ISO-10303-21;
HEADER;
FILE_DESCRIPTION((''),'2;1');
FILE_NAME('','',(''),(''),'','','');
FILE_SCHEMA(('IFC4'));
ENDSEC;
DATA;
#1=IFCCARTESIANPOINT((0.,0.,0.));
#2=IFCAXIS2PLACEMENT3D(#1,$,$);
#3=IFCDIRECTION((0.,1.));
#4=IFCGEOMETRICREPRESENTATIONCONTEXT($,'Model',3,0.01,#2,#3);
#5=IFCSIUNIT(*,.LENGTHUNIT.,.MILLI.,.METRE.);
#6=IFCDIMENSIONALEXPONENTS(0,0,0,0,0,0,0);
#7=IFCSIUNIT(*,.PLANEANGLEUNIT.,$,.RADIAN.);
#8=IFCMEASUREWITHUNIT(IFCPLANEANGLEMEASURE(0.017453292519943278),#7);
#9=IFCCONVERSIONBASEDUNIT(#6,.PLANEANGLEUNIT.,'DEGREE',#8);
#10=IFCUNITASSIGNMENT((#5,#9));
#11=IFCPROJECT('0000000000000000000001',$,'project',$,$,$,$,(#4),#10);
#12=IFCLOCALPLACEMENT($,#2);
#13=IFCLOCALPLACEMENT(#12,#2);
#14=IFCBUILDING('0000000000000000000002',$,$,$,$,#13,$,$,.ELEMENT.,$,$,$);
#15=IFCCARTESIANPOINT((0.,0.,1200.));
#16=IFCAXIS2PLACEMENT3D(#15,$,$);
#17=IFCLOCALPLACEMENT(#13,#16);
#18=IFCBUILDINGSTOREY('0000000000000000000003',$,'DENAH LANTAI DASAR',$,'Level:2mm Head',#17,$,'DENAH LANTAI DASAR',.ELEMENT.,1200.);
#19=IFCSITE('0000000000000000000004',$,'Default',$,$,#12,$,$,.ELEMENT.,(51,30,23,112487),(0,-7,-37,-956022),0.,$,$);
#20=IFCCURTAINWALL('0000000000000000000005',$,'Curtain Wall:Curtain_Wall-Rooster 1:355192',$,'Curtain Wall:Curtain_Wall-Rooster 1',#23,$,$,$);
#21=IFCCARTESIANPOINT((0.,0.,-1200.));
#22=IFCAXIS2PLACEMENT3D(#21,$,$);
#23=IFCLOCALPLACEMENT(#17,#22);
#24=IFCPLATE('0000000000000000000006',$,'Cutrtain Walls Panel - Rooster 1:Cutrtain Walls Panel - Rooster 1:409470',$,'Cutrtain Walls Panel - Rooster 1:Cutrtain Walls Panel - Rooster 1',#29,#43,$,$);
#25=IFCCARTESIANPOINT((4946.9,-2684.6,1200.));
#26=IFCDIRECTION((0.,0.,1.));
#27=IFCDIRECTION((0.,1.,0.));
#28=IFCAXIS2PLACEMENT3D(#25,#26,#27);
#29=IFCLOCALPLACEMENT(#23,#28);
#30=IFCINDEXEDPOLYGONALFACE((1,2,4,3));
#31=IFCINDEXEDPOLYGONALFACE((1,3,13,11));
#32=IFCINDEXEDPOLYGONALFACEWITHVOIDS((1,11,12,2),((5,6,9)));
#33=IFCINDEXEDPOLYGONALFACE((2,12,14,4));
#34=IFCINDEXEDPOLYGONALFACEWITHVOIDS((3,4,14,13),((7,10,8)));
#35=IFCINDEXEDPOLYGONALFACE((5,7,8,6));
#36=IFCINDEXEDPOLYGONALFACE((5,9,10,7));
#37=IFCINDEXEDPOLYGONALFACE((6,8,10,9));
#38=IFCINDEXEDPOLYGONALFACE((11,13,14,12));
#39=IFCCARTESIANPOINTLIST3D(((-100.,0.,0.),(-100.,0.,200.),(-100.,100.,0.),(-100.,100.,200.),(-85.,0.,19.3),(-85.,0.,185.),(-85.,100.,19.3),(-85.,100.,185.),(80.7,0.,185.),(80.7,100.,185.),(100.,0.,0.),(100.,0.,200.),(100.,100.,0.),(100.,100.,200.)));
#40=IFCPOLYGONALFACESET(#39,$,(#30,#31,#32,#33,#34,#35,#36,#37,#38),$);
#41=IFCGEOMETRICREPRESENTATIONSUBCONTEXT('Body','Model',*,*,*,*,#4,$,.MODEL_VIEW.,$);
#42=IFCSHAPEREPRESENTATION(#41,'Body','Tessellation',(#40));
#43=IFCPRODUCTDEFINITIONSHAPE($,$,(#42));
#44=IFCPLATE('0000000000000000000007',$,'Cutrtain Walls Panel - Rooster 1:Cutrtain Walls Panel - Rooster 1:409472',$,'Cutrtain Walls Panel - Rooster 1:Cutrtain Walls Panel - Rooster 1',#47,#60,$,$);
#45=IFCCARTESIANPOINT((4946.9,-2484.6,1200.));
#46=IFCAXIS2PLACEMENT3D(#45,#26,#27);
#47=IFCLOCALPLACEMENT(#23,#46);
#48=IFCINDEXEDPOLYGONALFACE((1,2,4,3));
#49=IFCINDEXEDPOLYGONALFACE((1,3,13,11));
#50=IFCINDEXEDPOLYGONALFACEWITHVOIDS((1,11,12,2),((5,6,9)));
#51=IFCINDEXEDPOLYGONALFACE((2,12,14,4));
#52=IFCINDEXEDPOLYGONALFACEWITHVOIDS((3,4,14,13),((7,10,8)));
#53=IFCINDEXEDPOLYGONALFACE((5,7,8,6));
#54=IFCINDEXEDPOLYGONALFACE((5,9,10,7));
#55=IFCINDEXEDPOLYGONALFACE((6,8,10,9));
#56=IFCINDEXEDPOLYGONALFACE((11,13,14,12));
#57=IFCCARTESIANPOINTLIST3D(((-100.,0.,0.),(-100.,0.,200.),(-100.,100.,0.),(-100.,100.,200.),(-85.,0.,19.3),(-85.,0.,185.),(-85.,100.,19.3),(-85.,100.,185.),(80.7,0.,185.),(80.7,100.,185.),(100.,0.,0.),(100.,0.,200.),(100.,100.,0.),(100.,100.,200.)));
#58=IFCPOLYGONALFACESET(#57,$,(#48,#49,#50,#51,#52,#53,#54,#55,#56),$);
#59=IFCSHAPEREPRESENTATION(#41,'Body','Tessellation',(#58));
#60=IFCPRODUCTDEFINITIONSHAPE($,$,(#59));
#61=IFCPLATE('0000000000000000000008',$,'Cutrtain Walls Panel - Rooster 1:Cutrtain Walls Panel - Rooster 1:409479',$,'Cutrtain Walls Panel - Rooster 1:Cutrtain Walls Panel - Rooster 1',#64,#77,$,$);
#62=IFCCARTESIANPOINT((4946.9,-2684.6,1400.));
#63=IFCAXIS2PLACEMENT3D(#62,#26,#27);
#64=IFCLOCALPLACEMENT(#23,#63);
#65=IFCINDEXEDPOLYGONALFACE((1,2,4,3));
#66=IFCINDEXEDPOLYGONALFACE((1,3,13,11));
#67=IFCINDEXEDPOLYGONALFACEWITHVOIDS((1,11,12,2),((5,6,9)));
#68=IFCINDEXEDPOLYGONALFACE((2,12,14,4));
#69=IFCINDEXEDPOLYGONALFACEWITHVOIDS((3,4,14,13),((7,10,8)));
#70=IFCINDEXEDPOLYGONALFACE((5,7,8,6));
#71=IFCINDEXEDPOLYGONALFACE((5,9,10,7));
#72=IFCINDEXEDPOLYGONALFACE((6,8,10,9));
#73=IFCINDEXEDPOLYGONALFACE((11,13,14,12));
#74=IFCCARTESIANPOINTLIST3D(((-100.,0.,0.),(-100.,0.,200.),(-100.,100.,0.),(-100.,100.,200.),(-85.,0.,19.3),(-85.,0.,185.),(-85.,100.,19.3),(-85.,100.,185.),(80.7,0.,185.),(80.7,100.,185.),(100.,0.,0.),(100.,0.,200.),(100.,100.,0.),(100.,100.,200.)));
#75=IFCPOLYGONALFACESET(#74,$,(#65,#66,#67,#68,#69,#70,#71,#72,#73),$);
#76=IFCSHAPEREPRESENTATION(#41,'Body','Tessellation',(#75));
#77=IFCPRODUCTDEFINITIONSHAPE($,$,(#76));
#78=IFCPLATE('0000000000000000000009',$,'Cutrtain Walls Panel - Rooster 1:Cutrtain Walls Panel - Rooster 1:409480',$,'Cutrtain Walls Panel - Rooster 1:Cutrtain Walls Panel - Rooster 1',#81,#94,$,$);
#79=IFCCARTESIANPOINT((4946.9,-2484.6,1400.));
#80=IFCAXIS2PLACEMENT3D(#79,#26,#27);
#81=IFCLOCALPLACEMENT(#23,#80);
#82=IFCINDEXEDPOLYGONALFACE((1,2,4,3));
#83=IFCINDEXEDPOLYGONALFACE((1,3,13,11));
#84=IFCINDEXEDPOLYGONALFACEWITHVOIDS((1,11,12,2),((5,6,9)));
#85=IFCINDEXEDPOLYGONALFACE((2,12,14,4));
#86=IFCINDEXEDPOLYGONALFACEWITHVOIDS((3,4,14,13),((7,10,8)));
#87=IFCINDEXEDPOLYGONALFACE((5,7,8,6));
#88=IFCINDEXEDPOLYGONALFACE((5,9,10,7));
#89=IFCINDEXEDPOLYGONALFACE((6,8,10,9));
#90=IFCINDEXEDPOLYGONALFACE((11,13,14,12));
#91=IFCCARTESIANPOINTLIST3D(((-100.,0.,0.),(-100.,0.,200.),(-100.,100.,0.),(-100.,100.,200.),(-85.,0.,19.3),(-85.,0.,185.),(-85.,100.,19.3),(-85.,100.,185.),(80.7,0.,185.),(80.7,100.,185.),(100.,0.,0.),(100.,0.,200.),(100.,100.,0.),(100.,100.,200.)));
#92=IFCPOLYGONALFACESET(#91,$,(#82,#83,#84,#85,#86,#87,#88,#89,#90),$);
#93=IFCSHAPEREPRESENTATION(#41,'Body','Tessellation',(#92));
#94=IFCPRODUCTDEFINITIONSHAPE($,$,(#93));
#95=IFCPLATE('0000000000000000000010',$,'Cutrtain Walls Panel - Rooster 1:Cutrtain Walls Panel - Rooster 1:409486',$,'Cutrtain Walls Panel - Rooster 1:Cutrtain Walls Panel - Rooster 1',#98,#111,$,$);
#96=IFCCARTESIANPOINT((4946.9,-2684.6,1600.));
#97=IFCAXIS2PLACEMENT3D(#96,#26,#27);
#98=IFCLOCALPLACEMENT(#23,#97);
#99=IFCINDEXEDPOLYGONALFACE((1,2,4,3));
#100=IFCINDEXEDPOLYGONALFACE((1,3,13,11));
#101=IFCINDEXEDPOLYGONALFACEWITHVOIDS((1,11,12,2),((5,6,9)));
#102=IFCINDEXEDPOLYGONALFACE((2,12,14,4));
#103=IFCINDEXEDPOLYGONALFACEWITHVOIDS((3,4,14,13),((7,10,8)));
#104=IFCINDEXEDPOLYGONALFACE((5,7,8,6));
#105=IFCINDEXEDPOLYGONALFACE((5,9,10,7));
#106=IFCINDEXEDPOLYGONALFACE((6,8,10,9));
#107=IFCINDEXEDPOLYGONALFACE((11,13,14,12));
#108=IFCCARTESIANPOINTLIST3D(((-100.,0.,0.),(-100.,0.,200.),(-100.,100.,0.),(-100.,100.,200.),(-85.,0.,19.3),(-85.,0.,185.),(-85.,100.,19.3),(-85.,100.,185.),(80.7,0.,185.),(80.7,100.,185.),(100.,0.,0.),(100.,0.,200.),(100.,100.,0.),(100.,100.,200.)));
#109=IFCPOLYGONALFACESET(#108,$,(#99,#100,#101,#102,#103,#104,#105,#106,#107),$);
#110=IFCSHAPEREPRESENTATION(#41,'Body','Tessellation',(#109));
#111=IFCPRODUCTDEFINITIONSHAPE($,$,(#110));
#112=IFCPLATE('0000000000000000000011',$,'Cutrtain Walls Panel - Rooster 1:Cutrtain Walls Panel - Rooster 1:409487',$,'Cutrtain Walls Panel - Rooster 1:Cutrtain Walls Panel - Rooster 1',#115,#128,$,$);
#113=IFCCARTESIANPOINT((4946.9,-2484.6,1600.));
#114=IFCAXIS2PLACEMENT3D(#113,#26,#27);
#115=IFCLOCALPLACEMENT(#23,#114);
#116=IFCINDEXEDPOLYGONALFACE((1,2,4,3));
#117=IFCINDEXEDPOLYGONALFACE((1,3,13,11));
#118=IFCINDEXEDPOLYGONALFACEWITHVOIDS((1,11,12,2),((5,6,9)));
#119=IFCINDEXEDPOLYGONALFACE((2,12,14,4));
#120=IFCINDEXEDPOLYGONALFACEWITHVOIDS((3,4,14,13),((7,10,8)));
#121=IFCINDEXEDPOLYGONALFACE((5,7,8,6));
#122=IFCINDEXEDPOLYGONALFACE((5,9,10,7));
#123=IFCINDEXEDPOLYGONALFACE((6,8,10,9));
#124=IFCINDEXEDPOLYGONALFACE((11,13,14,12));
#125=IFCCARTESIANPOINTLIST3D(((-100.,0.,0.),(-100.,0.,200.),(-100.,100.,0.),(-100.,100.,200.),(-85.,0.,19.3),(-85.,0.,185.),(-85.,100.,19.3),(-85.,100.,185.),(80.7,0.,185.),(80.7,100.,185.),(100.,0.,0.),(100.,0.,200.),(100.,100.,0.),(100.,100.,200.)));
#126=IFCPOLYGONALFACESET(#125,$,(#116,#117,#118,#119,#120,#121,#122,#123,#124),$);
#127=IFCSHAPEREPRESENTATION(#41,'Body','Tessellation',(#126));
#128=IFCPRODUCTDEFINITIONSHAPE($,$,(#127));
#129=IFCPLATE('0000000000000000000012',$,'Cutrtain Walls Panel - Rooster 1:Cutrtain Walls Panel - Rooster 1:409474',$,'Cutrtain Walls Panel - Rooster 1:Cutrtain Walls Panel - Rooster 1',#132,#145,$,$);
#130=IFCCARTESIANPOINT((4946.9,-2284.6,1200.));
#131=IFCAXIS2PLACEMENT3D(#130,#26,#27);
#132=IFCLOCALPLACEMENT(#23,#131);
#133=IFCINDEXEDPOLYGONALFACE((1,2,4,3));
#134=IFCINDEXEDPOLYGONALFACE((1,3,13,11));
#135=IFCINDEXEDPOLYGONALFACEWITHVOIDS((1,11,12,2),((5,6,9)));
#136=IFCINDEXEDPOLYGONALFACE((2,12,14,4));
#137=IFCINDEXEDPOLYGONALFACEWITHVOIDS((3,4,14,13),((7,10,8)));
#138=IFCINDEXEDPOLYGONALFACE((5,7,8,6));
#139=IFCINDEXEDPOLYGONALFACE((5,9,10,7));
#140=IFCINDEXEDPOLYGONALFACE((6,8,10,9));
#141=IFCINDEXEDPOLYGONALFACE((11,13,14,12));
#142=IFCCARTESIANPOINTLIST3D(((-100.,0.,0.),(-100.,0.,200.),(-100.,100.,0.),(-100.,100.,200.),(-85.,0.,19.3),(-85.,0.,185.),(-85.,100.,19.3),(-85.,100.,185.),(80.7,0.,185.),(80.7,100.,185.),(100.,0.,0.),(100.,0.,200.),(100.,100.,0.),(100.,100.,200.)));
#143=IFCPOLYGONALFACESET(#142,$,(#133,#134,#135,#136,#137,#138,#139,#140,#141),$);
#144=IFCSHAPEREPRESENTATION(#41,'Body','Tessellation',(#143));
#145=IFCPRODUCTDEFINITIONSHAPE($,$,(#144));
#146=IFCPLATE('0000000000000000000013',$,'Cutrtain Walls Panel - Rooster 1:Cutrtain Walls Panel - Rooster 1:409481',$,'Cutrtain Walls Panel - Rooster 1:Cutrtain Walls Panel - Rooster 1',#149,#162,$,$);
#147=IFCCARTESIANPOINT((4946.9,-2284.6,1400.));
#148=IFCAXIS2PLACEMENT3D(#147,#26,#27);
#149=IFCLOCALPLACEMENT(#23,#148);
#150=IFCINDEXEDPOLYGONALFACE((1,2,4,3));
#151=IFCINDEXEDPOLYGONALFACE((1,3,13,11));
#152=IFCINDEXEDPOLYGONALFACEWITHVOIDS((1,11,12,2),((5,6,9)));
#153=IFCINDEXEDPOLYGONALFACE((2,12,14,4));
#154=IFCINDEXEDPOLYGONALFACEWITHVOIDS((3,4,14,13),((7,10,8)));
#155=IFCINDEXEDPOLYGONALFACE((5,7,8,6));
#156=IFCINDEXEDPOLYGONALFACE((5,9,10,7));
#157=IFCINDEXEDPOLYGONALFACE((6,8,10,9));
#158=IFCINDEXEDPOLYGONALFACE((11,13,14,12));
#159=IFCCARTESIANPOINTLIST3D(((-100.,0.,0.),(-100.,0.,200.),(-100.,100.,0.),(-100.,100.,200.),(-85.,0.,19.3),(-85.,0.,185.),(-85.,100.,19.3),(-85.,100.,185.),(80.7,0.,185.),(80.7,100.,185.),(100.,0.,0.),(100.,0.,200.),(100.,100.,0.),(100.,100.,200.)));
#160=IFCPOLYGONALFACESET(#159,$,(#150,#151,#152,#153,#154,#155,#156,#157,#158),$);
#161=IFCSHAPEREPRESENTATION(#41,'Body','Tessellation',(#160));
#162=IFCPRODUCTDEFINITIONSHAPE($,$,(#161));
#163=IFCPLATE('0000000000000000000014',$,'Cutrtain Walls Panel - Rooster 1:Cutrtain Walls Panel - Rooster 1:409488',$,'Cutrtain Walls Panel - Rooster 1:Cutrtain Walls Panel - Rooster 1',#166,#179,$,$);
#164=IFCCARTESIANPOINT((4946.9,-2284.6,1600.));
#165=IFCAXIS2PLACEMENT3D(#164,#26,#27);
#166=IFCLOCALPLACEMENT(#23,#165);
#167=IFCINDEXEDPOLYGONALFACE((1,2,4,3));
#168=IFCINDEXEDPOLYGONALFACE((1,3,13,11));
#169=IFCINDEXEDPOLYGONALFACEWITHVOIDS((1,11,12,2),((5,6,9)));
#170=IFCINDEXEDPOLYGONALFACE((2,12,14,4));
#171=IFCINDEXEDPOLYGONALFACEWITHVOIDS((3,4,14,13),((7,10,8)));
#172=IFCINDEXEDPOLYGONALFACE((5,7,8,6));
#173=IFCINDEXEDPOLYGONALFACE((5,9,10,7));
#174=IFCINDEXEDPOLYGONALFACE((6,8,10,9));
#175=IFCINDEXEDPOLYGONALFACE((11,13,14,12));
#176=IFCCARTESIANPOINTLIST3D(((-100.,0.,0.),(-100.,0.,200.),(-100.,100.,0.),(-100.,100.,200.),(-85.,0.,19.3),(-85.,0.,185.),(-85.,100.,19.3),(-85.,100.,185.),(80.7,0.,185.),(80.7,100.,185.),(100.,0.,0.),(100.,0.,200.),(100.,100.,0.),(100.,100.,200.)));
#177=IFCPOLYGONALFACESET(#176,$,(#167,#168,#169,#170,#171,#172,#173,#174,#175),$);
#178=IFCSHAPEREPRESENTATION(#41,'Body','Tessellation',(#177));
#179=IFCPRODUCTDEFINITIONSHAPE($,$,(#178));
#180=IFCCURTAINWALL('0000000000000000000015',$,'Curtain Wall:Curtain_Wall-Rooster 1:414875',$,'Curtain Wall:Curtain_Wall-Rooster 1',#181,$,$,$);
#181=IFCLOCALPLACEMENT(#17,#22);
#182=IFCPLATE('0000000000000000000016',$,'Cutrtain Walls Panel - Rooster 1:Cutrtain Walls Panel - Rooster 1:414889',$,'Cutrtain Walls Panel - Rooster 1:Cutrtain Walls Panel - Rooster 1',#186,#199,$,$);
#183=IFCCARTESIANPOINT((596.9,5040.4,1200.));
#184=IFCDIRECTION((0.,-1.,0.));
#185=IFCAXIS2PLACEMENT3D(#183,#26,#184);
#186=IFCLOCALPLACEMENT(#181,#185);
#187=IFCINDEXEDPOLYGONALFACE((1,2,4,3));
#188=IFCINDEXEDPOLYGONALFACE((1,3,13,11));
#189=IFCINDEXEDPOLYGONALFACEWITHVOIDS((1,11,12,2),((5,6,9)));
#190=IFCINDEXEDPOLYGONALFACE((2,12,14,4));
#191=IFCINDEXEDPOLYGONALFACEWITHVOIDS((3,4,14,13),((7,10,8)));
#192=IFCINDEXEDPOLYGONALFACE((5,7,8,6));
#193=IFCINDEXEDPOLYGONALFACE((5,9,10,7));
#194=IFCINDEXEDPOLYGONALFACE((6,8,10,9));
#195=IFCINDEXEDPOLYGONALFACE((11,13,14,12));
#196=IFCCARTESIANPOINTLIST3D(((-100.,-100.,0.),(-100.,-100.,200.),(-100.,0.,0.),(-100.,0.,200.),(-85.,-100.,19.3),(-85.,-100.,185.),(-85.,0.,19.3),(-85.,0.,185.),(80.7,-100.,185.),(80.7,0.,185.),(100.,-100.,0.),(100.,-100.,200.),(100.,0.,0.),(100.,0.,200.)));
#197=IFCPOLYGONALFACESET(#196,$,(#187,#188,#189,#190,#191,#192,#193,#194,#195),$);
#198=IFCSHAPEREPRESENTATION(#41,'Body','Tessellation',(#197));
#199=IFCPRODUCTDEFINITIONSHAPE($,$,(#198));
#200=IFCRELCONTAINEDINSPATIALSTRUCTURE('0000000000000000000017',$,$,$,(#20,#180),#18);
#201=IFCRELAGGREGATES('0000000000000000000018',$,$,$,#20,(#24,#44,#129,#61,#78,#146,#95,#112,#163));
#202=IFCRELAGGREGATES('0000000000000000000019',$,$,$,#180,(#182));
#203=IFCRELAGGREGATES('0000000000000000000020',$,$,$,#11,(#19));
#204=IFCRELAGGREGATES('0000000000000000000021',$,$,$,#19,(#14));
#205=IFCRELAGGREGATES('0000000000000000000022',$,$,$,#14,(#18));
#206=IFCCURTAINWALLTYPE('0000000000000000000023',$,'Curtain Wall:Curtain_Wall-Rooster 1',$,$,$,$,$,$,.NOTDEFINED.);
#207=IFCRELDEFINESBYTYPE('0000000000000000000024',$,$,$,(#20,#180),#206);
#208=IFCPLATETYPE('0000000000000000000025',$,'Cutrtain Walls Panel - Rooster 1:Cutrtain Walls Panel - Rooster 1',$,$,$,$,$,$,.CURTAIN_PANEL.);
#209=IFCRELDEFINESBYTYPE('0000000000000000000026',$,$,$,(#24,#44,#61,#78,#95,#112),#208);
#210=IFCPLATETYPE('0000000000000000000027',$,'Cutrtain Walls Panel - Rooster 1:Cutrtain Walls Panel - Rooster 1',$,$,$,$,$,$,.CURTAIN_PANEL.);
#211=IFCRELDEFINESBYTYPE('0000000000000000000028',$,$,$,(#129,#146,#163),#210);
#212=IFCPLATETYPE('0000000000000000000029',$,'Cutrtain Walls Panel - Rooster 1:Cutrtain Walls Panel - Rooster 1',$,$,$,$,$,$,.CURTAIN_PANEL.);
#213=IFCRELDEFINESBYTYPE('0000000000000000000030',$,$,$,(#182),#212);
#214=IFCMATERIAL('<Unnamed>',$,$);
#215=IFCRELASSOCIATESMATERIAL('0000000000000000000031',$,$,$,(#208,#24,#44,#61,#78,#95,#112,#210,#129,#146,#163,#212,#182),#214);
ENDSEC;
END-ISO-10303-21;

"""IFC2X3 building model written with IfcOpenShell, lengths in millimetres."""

from ifc_helpers import new_model, entity, si_unit, converted_unit, direction, frame, origin, place, context, subcontext, project, spatial, polyline, outline, extrude, source, transform, mapped, material, type_object, type_shapes, element, aggregate, save


model = new_model("IFC2X3")

# Units and contexts
model_context = context("Model", 3, precision=0.01, world=origin(), true_north=direction((0.0, 1.0)))
body_context = subcontext(model_context, "Body", "Model", "MODEL_VIEW")
ifc_project = project(units=[si_unit("LENGTHUNIT", "METRE", prefix="MILLI"), converted_unit("PLANEANGLEUNIT", "DEGREE", entity("IfcPlaneAngleMeasure", 0.017453292519943278), si_unit("PLANEANGLEUNIT", "RADIAN"), dimensions=[0, 0, 0, 0, 0, 0, 0])], contexts=[model_context])

# Site, building, storey
site_placement = place(None, origin())
site = spatial("IfcSite", under=ifc_project, at=site_placement, Name="Default", CompositionType="ELEMENT", RefLatitude=(51, 30, 23, 112487), RefLongitude=(0, -7, -37, -956022), RefElevation=0.0)
building_placement = place(site_placement, origin())
building = spatial("IfcBuilding", under=site, at=building_placement, CompositionType="ELEMENT")
storey_placement = place(building_placement, frame((0.0, 0.0, 1200.0)))
storey = spatial("IfcBuildingStorey", under=building, at=storey_placement, Name="DENAH LANTAI DASAR", ObjectType="Level:2mm Head", LongName="DENAH LANTAI DASAR", CompositionType="ELEMENT", Elevation=1200.0)

# Curtain wall, plates
curtain_wall_type = type_object("IfcCurtainWallType", Name="Curtain Wall:Curtain_Wall-Rooster 1", PredefinedType="NOTDEFINED")
curtain_wall_1_placement = place(storey_placement, frame((0.0, 0.0, -1200.0)))
curtain_wall_1 = element("IfcCurtainWall", 1, at=curtain_wall_1_placement, inside=storey, type_object=curtain_wall_type, Name="Curtain Wall:Curtain_Wall-Rooster 1:355192", ObjectType="Curtain Wall:Curtain_Wall-Rooster 1")
ifc_material_1 = material(Name="<Unnamed>")
plate_type_1 = type_object("IfcPlateType", Name="Cutrtain Walls Panel - Rooster 1:Cutrtain Walls Panel - Rooster 1", PredefinedType="CURTAIN_PANEL", material=ifc_material_1)
shared_shape_1 = source(origin(), body_context, "Body", "SweptSolid", [
    extrude(outline(polyline([(-100.0, -100.0), (100.0, -100.0), (100.0, 100.0), (-100.0, 100.0), (-100.0, -100.0)]), holes=[polyline([(80.7, 85.0), (-85.0, -80.7), (-85.0, 85.0), (80.7, 85.0)])]), frame((0.0, 0.0, 100.0), z_axis=(0.0, 1.0, 0.0), x_axis=(0.0, 0.0, -1.0)), (0.0, 0.0, 1.0), 100.0),
])
type_shapes(plate_type_1, [shared_shape_1])
plate_1_placement = place(curtain_wall_1_placement, frame((4946.9, -2684.6, 1200.0), z_axis=(0.0, 0.0, 1.0), x_axis=(0.0, 1.0, 0.0)))
plate_1 = element("IfcPlate", 2, at=plate_1_placement, type_object=plate_type_1, material=ifc_material_1, Name="Cutrtain Walls Panel - Rooster 1:Cutrtain Walls Panel - Rooster 1:409470", ObjectType="Cutrtain Walls Panel - Rooster 1:Cutrtain Walls Panel - Rooster 1", context=body_context, shape_type="MappedRepresentation", body=[
    mapped(shared_shape_1, transform((0.0, 0.0, 0.0), scale=1.0)),
])
plate_2_placement = place(curtain_wall_1_placement, frame((4946.9, -2484.6, 1200.0), z_axis=(0.0, 0.0, 1.0), x_axis=(0.0, 1.0, 0.0)))
plate_2 = element("IfcPlate", 3, at=plate_2_placement, type_object=plate_type_1, material=ifc_material_1, Name="Cutrtain Walls Panel - Rooster 1:Cutrtain Walls Panel - Rooster 1:409472", ObjectType="Cutrtain Walls Panel - Rooster 1:Cutrtain Walls Panel - Rooster 1", context=body_context, shape_type="MappedRepresentation", body=[
    mapped(shared_shape_1, transform((0.0, 0.0, 0.0), scale=1.0)),
])
plate_3_placement = place(curtain_wall_1_placement, frame((4946.9, -2684.6, 1400.0), z_axis=(0.0, 0.0, 1.0), x_axis=(0.0, 1.0, 0.0)))
plate_3 = element("IfcPlate", 4, at=plate_3_placement, type_object=plate_type_1, material=ifc_material_1, Name="Cutrtain Walls Panel - Rooster 1:Cutrtain Walls Panel - Rooster 1:409479", ObjectType="Cutrtain Walls Panel - Rooster 1:Cutrtain Walls Panel - Rooster 1", context=body_context, shape_type="MappedRepresentation", body=[
    mapped(shared_shape_1, transform((0.0, 0.0, 0.0), scale=1.0)),
])
plate_4_placement = place(curtain_wall_1_placement, frame((4946.9, -2484.6, 1400.0), z_axis=(0.0, 0.0, 1.0), x_axis=(0.0, 1.0, 0.0)))
plate_4 = element("IfcPlate", 5, at=plate_4_placement, type_object=plate_type_1, material=ifc_material_1, Name="Cutrtain Walls Panel - Rooster 1:Cutrtain Walls Panel - Rooster 1:409480", ObjectType="Cutrtain Walls Panel - Rooster 1:Cutrtain Walls Panel - Rooster 1", context=body_context, shape_type="MappedRepresentation", body=[
    mapped(shared_shape_1, transform((0.0, 0.0, 0.0), scale=1.0)),
])
plate_5_placement = place(curtain_wall_1_placement, frame((4946.9, -2684.6, 1600.0), z_axis=(0.0, 0.0, 1.0), x_axis=(0.0, 1.0, 0.0)))
plate_5 = element("IfcPlate", 6, at=plate_5_placement, type_object=plate_type_1, material=ifc_material_1, Name="Cutrtain Walls Panel - Rooster 1:Cutrtain Walls Panel - Rooster 1:409486", ObjectType="Cutrtain Walls Panel - Rooster 1:Cutrtain Walls Panel - Rooster 1", context=body_context, shape_type="MappedRepresentation", body=[
    mapped(shared_shape_1, transform((0.0, 0.0, 0.0), scale=1.0)),
])
plate_6_placement = place(curtain_wall_1_placement, frame((4946.9, -2484.6, 1600.0), z_axis=(0.0, 0.0, 1.0), x_axis=(0.0, 1.0, 0.0)))
plate_6 = element("IfcPlate", 7, at=plate_6_placement, type_object=plate_type_1, material=ifc_material_1, Name="Cutrtain Walls Panel - Rooster 1:Cutrtain Walls Panel - Rooster 1:409487", ObjectType="Cutrtain Walls Panel - Rooster 1:Cutrtain Walls Panel - Rooster 1", context=body_context, shape_type="MappedRepresentation", body=[
    mapped(shared_shape_1, transform((0.0, 0.0, 0.0), scale=1.0)),
])
plate_type_2 = type_object("IfcPlateType", Name="Cutrtain Walls Panel - Rooster 1:Cutrtain Walls Panel - Rooster 1", PredefinedType="CURTAIN_PANEL", material=ifc_material_1)
shared_shape_2 = source(origin(), body_context, "Body", "SweptSolid", [
    extrude(outline(polyline([(-100.0, -100.0), (100.0, -100.0), (100.0, 100.0), (-100.0, 100.0), (-100.0, -100.0)]), holes=[polyline([(80.7, 85.0), (-85.0, -80.7), (-85.0, 85.0), (80.7, 85.0)])]), frame((0.0, 0.0, 100.0), z_axis=(0.0, 1.0, 0.0), x_axis=(0.0, 0.0, -1.0)), (0.0, 0.0, 1.0), 100.0),
])
type_shapes(plate_type_2, [shared_shape_2])
plate_7_placement = place(curtain_wall_1_placement, frame((4946.9, -2284.6, 1200.0), z_axis=(0.0, 0.0, 1.0), x_axis=(0.0, 1.0, 0.0)))
plate_7 = element("IfcPlate", 8, at=plate_7_placement, type_object=plate_type_2, material=ifc_material_1, Name="Cutrtain Walls Panel - Rooster 1:Cutrtain Walls Panel - Rooster 1:409474", ObjectType="Cutrtain Walls Panel - Rooster 1:Cutrtain Walls Panel - Rooster 1", context=body_context, shape_type="MappedRepresentation", body=[
    mapped(shared_shape_2, transform((0.0, 0.0, 0.0), scale=1.0)),
])
plate_8_placement = place(curtain_wall_1_placement, frame((4946.9, -2284.6, 1400.0), z_axis=(0.0, 0.0, 1.0), x_axis=(0.0, 1.0, 0.0)))
plate_8 = element("IfcPlate", 9, at=plate_8_placement, type_object=plate_type_2, material=ifc_material_1, Name="Cutrtain Walls Panel - Rooster 1:Cutrtain Walls Panel - Rooster 1:409481", ObjectType="Cutrtain Walls Panel - Rooster 1:Cutrtain Walls Panel - Rooster 1", context=body_context, shape_type="MappedRepresentation", body=[
    mapped(shared_shape_2, transform((0.0, 0.0, 0.0), scale=1.0)),
])
plate_9_placement = place(curtain_wall_1_placement, frame((4946.9, -2284.6, 1600.0), z_axis=(0.0, 0.0, 1.0), x_axis=(0.0, 1.0, 0.0)))
plate_9 = element("IfcPlate", 10, at=plate_9_placement, type_object=plate_type_2, material=ifc_material_1, Name="Cutrtain Walls Panel - Rooster 1:Cutrtain Walls Panel - Rooster 1:409488", ObjectType="Cutrtain Walls Panel - Rooster 1:Cutrtain Walls Panel - Rooster 1", context=body_context, shape_type="MappedRepresentation", body=[
    mapped(shared_shape_2, transform((0.0, 0.0, 0.0), scale=1.0)),
])
aggregate(curtain_wall_1, [plate_1, plate_2, plate_7, plate_3, plate_4, plate_8, plate_5, plate_6, plate_9])

# Curtain wall, plate
curtain_wall_2_placement = place(storey_placement, frame((0.0, 0.0, -1200.0)))
curtain_wall_2 = element("IfcCurtainWall", 11, at=curtain_wall_2_placement, inside=storey, type_object=curtain_wall_type, Name="Curtain Wall:Curtain_Wall-Rooster 1:414875", ObjectType="Curtain Wall:Curtain_Wall-Rooster 1")
plate_type_3 = type_object("IfcPlateType", Name="Cutrtain Walls Panel - Rooster 1:Cutrtain Walls Panel - Rooster 1", PredefinedType="CURTAIN_PANEL", material=ifc_material_1)
shared_shape_3 = source(origin(), body_context, "Body", "SweptSolid", [
    extrude(outline(polyline([(-100.0, -100.0), (100.0, -100.0), (100.0, 100.0), (-100.0, 100.0), (-100.0, -100.0)]), holes=[polyline([(80.7, 85.0), (-85.0, -80.7), (-85.0, 85.0), (80.7, 85.0)])]), frame((0.0, -100.0, 100.0), z_axis=(0.0, 1.0, 0.0), x_axis=(0.0, 0.0, -1.0)), (0.0, 0.0, 1.0), 100.0),
])
type_shapes(plate_type_3, [shared_shape_3])
plate_10_placement = place(curtain_wall_2_placement, frame((596.9, 5040.4, 1200.0), z_axis=(0.0, 0.0, 1.0), x_axis=(0.0, -1.0, 0.0)))
plate_10 = element("IfcPlate", 12, at=plate_10_placement, type_object=plate_type_3, material=ifc_material_1, Name="Cutrtain Walls Panel - Rooster 1:Cutrtain Walls Panel - Rooster 1:414889", ObjectType="Cutrtain Walls Panel - Rooster 1:Cutrtain Walls Panel - Rooster 1", context=body_context, shape_type="MappedRepresentation", body=[
    mapped(shared_shape_3, transform((0.0, 0.0, 0.0), scale=1.0)),
])
aggregate(curtain_wall_2, [plate_10])

save(model, "model.ifc")
